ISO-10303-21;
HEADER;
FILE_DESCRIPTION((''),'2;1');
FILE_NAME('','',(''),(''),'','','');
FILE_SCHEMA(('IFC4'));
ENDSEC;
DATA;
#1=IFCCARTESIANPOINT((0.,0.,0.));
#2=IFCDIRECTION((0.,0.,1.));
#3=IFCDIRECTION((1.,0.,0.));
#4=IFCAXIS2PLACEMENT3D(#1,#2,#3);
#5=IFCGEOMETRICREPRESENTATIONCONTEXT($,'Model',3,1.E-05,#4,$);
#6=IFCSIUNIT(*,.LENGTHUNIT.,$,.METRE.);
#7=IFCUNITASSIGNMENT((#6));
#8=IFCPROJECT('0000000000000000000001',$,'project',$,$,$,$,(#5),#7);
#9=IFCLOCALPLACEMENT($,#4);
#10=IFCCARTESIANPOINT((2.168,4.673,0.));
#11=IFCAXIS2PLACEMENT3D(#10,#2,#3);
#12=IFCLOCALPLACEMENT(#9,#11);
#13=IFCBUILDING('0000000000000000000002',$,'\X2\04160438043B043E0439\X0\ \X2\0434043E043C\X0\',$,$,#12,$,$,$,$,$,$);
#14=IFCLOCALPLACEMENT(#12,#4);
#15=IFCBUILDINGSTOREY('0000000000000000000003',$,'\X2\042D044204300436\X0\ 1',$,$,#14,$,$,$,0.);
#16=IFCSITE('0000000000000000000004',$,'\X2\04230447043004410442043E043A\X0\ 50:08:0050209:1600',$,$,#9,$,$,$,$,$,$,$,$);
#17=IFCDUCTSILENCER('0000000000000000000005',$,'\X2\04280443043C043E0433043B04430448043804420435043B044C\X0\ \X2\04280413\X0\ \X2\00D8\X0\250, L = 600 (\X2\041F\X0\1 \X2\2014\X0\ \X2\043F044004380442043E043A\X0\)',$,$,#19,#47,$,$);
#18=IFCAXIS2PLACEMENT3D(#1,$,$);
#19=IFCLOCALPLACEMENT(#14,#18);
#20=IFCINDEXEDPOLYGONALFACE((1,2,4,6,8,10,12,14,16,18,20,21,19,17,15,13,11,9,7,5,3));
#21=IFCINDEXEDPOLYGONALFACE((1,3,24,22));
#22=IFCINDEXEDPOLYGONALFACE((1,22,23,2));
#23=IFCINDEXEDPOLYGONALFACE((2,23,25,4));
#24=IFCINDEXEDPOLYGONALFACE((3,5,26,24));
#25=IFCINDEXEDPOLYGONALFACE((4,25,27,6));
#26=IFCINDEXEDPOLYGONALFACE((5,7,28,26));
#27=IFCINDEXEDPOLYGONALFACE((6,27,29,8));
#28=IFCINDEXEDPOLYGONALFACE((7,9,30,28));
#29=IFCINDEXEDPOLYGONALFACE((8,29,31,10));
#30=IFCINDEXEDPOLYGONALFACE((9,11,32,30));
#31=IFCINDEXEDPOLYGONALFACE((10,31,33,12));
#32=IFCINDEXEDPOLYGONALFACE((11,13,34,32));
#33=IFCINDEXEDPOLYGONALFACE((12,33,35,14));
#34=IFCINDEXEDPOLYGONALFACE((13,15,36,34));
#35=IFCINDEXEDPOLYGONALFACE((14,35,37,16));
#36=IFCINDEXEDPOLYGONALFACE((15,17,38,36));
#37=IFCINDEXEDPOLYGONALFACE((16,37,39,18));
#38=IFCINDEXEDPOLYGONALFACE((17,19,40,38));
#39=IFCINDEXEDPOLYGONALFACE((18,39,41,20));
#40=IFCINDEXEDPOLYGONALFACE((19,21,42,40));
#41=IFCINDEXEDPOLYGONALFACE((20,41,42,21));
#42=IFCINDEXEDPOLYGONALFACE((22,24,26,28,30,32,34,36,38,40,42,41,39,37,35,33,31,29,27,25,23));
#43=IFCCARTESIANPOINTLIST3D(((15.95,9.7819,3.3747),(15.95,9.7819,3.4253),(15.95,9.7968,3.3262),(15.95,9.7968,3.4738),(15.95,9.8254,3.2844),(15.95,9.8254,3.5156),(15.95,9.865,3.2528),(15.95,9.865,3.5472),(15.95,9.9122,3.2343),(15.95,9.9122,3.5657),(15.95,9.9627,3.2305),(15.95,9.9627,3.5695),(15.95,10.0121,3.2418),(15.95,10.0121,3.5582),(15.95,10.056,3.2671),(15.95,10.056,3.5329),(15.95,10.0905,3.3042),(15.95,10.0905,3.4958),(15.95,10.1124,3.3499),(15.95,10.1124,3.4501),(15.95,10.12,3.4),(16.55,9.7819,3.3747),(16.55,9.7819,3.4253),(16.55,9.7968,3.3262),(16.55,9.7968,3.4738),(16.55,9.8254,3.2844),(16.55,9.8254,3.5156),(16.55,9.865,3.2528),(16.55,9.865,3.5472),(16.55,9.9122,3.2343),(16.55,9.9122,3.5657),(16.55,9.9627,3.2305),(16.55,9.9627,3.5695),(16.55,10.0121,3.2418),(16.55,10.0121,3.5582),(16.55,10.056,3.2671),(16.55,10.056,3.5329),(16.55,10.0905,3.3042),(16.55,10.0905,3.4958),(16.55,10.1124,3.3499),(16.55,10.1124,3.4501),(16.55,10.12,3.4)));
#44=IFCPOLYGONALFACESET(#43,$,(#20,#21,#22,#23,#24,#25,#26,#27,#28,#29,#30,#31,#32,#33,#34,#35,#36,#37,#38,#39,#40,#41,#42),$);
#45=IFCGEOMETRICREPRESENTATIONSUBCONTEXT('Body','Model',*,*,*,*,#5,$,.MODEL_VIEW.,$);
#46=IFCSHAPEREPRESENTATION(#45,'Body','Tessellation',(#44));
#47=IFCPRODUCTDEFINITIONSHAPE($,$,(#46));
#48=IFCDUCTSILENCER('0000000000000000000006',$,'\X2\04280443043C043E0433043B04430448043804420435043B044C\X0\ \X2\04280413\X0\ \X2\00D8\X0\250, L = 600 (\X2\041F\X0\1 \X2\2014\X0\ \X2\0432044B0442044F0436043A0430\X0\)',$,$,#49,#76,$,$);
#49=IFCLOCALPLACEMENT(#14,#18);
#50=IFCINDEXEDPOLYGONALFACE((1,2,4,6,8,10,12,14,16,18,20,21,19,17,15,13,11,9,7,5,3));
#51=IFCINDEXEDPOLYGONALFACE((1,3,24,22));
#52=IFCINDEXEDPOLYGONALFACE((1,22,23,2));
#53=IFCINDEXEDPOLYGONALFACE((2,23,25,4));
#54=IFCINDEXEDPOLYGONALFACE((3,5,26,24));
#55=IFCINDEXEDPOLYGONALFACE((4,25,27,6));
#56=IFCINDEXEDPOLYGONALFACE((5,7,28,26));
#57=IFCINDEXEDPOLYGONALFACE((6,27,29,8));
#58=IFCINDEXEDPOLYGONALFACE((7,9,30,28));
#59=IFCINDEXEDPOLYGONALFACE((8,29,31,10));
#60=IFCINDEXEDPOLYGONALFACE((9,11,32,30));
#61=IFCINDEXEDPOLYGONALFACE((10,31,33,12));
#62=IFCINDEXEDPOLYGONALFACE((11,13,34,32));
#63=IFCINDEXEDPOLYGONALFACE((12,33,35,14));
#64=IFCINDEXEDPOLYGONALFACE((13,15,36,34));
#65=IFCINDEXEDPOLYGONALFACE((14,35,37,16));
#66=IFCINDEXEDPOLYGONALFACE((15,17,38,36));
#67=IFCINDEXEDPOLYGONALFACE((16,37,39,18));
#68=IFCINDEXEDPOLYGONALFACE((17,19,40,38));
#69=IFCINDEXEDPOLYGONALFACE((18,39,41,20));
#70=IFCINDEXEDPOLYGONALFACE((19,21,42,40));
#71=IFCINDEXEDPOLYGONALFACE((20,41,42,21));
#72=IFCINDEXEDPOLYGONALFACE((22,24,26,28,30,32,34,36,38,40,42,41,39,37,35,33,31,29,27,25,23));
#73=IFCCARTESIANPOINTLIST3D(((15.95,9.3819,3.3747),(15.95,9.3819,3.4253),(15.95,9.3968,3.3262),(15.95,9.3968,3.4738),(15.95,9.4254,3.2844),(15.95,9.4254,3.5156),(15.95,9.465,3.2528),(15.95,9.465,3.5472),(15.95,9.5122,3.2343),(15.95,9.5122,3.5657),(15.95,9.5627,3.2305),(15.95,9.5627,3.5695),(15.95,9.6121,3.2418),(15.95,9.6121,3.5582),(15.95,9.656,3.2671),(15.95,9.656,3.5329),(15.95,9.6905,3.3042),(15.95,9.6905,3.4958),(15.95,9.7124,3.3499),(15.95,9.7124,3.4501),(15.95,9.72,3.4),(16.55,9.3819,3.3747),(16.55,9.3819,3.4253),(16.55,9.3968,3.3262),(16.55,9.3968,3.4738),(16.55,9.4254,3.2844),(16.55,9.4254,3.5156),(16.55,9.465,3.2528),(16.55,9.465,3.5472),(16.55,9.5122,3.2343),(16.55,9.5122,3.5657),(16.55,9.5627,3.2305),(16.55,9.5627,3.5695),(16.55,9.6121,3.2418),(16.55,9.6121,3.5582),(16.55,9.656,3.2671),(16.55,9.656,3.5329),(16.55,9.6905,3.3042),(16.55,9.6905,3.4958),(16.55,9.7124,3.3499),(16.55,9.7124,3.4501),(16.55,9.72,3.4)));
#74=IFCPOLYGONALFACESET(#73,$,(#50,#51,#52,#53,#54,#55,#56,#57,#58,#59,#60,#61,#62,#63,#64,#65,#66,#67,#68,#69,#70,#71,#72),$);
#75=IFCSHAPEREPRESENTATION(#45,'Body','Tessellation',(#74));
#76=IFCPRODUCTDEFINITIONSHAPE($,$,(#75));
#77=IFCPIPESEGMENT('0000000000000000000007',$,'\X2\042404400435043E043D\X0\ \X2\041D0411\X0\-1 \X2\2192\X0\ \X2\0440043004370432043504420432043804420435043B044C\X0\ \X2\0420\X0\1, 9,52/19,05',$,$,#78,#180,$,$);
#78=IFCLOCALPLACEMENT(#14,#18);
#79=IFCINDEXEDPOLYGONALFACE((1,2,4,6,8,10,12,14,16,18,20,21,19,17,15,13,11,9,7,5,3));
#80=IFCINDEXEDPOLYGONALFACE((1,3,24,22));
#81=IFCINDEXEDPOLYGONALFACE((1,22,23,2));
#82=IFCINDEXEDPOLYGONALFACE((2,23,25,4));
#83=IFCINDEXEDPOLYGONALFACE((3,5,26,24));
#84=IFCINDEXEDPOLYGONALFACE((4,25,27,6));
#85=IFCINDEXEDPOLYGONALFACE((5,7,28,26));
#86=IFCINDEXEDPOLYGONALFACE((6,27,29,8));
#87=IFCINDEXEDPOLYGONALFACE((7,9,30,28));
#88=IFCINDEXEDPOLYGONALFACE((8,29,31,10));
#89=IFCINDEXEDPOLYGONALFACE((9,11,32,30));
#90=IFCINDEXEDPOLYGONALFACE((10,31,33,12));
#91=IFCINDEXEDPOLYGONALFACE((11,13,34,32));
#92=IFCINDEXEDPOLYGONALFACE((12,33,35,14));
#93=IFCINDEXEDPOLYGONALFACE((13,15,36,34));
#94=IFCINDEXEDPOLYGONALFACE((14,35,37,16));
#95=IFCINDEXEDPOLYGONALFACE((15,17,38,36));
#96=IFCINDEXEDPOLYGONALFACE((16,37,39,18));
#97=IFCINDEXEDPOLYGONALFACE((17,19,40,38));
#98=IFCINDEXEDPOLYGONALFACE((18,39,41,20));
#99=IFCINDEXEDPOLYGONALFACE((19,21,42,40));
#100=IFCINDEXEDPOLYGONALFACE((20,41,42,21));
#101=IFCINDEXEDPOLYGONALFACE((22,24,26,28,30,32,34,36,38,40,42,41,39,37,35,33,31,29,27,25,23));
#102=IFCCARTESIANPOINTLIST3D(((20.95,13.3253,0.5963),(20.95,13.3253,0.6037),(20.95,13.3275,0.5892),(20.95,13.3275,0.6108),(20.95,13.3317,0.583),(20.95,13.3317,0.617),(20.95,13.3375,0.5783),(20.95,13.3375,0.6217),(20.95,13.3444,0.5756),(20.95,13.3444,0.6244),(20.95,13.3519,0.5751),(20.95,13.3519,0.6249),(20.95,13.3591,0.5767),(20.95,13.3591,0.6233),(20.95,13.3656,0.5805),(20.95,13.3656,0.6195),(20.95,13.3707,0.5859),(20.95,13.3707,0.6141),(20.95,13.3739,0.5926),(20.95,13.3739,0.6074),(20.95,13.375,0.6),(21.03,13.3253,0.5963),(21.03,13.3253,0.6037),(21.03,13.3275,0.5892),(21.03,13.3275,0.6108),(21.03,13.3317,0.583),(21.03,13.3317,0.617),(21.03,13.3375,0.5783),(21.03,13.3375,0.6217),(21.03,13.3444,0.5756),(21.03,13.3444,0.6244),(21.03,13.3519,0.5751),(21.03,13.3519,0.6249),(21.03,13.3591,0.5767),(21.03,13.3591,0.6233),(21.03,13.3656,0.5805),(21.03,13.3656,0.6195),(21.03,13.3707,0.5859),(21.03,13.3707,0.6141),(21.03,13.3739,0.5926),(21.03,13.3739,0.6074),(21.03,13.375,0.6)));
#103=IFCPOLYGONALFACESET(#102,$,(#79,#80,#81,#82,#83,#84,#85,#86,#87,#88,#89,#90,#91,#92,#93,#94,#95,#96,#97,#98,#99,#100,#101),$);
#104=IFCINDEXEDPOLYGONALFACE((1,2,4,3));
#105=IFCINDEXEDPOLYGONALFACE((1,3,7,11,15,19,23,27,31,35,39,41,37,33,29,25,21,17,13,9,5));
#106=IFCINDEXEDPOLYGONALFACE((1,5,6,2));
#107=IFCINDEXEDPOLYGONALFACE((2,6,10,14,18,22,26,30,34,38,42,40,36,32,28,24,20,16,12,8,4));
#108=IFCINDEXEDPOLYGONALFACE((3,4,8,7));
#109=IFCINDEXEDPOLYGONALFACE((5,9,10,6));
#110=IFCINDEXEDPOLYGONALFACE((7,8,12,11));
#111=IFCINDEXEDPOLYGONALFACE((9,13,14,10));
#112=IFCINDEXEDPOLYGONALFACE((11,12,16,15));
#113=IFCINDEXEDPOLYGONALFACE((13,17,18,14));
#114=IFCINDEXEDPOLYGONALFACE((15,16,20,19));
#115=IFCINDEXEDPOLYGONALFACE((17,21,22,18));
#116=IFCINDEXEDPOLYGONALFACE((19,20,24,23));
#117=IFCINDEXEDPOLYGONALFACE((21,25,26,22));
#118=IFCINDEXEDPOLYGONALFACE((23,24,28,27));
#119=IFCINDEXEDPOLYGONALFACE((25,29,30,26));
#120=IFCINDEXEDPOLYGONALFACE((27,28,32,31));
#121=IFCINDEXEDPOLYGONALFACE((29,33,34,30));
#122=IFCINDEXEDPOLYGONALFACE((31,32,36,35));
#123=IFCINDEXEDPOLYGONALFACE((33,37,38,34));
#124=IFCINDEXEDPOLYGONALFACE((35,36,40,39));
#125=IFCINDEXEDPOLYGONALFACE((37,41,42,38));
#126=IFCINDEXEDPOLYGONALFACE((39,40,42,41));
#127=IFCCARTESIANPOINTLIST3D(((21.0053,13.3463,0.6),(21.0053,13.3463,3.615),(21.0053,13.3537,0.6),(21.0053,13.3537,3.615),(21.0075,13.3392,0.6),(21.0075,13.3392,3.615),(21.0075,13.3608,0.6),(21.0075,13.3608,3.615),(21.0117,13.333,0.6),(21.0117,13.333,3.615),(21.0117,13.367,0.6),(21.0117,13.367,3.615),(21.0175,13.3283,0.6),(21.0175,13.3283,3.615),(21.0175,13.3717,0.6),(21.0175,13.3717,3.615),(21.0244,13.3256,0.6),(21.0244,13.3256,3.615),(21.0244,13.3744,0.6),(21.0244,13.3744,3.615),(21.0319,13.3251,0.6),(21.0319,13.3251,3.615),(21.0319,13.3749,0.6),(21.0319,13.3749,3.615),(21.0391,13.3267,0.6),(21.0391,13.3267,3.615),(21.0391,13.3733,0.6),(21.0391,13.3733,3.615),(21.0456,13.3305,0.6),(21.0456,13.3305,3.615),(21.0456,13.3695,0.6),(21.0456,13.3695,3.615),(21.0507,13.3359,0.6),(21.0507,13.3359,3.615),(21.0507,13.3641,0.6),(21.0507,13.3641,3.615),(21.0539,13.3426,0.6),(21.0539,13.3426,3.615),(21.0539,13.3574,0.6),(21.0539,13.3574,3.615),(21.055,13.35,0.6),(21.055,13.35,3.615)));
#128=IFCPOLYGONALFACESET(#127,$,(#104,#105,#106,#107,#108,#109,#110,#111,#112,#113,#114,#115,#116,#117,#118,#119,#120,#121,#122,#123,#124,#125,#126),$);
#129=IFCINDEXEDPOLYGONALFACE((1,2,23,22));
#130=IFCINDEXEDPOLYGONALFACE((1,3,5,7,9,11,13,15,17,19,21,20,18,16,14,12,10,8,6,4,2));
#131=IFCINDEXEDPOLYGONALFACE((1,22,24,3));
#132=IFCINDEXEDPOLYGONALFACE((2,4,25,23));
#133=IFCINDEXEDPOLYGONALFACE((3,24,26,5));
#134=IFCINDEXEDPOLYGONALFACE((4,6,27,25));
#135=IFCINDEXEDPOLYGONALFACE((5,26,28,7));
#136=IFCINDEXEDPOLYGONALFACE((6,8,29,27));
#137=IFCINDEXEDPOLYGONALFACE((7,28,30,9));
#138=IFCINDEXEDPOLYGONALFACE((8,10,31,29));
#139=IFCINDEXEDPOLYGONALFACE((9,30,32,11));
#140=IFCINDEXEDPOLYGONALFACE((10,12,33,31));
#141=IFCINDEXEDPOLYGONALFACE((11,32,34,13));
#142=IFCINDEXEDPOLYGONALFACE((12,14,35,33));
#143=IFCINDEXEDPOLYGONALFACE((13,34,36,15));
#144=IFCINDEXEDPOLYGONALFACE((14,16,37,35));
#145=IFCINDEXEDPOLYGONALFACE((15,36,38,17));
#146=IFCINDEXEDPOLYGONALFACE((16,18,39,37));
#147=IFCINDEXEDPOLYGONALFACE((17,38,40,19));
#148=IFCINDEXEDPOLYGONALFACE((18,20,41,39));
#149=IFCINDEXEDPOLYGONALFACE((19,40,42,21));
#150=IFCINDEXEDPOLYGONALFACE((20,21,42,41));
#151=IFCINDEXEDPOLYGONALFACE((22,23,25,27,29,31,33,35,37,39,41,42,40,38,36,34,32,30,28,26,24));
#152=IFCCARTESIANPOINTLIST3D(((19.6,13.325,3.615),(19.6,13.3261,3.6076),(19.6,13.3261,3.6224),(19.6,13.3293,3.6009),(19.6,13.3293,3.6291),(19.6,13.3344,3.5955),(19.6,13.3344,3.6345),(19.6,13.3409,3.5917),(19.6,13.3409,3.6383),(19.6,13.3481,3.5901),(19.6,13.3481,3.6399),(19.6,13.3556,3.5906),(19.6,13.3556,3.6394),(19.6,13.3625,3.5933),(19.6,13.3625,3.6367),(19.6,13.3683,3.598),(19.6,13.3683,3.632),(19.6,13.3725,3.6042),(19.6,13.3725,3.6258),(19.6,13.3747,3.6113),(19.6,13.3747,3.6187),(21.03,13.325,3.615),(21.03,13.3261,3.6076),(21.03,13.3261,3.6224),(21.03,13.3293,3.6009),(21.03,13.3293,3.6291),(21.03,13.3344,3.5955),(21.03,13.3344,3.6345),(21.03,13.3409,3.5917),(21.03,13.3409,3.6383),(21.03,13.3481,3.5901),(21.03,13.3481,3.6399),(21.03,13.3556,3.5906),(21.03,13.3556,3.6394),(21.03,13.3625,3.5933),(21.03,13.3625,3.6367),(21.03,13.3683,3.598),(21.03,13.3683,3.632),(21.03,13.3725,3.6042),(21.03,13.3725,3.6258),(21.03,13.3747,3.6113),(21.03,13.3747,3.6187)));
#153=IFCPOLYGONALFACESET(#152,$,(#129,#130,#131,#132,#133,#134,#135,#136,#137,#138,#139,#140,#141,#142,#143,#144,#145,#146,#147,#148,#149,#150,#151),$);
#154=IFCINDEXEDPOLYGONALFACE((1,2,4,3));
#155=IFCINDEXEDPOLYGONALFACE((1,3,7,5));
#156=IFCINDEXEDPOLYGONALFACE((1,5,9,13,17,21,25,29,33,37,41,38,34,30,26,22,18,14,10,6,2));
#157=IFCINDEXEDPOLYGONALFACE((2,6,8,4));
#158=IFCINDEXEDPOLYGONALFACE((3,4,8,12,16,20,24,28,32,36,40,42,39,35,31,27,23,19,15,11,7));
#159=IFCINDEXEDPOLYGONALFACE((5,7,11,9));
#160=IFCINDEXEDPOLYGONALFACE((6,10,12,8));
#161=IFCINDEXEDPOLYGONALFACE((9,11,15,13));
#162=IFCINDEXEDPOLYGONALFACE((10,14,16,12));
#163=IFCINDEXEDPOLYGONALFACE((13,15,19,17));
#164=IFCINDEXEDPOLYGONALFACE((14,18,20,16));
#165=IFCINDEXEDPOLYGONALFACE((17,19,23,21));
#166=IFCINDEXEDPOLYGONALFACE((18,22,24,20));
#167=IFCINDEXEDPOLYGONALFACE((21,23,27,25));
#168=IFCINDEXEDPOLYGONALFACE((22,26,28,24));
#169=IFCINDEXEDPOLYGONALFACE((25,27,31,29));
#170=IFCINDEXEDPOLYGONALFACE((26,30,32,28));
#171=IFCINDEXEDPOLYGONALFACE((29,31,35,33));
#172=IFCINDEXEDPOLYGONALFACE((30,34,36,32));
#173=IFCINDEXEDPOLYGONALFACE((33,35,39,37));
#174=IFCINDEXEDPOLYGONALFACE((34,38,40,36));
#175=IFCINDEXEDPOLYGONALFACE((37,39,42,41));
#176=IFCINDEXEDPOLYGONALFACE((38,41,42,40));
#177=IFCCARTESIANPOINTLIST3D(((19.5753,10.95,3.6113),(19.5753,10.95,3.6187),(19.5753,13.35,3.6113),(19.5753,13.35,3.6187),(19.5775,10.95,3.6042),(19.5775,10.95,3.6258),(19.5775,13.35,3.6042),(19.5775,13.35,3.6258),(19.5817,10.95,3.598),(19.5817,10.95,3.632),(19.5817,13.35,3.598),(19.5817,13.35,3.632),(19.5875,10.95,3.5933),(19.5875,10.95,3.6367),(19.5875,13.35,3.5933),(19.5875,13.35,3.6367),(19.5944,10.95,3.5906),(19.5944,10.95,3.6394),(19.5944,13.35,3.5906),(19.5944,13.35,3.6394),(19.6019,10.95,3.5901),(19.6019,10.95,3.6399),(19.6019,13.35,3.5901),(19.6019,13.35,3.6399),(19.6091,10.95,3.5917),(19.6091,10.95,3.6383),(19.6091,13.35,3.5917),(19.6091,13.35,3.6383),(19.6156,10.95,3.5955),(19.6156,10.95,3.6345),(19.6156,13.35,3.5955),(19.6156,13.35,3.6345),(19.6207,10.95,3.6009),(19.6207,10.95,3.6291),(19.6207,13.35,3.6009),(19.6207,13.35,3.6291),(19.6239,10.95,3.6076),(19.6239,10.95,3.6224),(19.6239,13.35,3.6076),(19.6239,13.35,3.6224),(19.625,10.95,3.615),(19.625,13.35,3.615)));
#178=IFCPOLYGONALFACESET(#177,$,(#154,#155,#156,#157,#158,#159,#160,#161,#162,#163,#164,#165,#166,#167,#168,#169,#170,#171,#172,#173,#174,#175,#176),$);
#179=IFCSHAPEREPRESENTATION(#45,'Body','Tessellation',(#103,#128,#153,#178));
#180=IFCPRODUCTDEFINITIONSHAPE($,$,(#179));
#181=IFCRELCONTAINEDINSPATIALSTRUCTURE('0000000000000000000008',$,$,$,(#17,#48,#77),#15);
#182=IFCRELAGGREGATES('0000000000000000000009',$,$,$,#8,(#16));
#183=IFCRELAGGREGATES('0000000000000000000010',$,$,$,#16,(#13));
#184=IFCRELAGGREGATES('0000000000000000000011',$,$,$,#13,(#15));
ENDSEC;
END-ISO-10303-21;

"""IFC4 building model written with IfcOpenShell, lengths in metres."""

from ifc_helpers import new_model, si_unit, frame, origin_with_axes, origin_2d, place, context, subcontext, project, spatial, circle, extrude, element, save


model = new_model("IFC4")

# Units and contexts
model_context = context("Model", 3, precision=1e-05, world=origin_with_axes())
body_context = subcontext(model_context, "Body", "Model", "MODEL_VIEW")
ifc_project = project(units=[si_unit("LENGTHUNIT", "METRE")], contexts=[model_context])

# Site, building, storey
site_placement = place(None, origin_with_axes())
site = spatial("IfcSite", under=ifc_project, at=site_placement, Name="Участок 50:08:0050209:1600")
building_placement = place(site_placement, frame((2.168, 4.673, 0.0), z_axis=(0.0, 0.0, 1.0), x_axis=(1.0, 0.0, 0.0)))
building = spatial("IfcBuilding", under=site, at=building_placement, Name="Жилой дом")
storey_placement = place(building_placement, origin_with_axes())
storey = spatial("IfcBuildingStorey", under=building, at=storey_placement, Name="Этаж 1", Elevation=0.0)

# Duct silencers
duct_silencer_1_placement = place(storey_placement, origin_with_axes())
element("IfcDuctSilencer", 1, at=duct_silencer_1_placement, inside=storey, Name="Шумоглушитель ШГ Ø250, L = 600 (П1 — приток)", context=body_context, shape_type="SweptSolid", body=[
    extrude(circle(Radius=0.17, at=origin_2d()), frame((15.95, 9.95, 3.4), z_axis=(1.0, 0.0, 0.0), x_axis=(0.0, 1.0, 0.0)), (0.0, 0.0, 1.0), 0.6),
])
duct_silencer_2_placement = place(storey_placement, origin_with_axes())
element("IfcDuctSilencer", 2, at=duct_silencer_2_placement, inside=storey, Name="Шумоглушитель ШГ Ø250, L = 600 (П1 — вытяжка)", context=body_context, shape_type="SweptSolid", body=[
    extrude(circle(Radius=0.17, at=origin_2d()), frame((15.95, 9.55, 3.4), z_axis=(1.0, 0.0, 0.0), x_axis=(0.0, 1.0, 0.0)), (0.0, 0.0, 1.0), 0.6),
])

# Pipe segment
pipe_segment_1_placement = place(storey_placement, origin_with_axes())
element("IfcPipeSegment", 3, at=pipe_segment_1_placement, inside=storey, Name="Фреон НБ-1 → разветвитель Р1, 9,52/19,05", context=body_context, shape_type="SweptSolid", body=[
    extrude(circle(Radius=0.025, at=origin_2d()), frame((20.95, 13.35, 0.6), z_axis=(1.0, 0.0, 0.0), x_axis=(0.0, 1.0, 0.0)), (0.0, 0.0, 1.0), 0.08),
    extrude(circle(Radius=0.025, at=origin_2d()), frame((21.03, 13.35, 0.6), z_axis=(0.0, 0.0, 1.0), x_axis=(1.0, 0.0, 0.0)), (0.0, 0.0, 1.0), 3.015),
    extrude(circle(Radius=0.025, at=origin_2d()), frame((21.03, 13.35, 3.615), z_axis=(-1.0, 0.0, 0.0), x_axis=(0.0, -1.0, 0.0)), (0.0, 0.0, 1.0), 1.43),
    extrude(circle(Radius=0.025, at=origin_2d()), frame((19.6, 13.35, 3.615), z_axis=(0.0, -1.0, 0.0), x_axis=(1.0, 0.0, 0.0)), (0.0, 0.0, 1.0), 2.4),
])

save(model, "model.ifc")
